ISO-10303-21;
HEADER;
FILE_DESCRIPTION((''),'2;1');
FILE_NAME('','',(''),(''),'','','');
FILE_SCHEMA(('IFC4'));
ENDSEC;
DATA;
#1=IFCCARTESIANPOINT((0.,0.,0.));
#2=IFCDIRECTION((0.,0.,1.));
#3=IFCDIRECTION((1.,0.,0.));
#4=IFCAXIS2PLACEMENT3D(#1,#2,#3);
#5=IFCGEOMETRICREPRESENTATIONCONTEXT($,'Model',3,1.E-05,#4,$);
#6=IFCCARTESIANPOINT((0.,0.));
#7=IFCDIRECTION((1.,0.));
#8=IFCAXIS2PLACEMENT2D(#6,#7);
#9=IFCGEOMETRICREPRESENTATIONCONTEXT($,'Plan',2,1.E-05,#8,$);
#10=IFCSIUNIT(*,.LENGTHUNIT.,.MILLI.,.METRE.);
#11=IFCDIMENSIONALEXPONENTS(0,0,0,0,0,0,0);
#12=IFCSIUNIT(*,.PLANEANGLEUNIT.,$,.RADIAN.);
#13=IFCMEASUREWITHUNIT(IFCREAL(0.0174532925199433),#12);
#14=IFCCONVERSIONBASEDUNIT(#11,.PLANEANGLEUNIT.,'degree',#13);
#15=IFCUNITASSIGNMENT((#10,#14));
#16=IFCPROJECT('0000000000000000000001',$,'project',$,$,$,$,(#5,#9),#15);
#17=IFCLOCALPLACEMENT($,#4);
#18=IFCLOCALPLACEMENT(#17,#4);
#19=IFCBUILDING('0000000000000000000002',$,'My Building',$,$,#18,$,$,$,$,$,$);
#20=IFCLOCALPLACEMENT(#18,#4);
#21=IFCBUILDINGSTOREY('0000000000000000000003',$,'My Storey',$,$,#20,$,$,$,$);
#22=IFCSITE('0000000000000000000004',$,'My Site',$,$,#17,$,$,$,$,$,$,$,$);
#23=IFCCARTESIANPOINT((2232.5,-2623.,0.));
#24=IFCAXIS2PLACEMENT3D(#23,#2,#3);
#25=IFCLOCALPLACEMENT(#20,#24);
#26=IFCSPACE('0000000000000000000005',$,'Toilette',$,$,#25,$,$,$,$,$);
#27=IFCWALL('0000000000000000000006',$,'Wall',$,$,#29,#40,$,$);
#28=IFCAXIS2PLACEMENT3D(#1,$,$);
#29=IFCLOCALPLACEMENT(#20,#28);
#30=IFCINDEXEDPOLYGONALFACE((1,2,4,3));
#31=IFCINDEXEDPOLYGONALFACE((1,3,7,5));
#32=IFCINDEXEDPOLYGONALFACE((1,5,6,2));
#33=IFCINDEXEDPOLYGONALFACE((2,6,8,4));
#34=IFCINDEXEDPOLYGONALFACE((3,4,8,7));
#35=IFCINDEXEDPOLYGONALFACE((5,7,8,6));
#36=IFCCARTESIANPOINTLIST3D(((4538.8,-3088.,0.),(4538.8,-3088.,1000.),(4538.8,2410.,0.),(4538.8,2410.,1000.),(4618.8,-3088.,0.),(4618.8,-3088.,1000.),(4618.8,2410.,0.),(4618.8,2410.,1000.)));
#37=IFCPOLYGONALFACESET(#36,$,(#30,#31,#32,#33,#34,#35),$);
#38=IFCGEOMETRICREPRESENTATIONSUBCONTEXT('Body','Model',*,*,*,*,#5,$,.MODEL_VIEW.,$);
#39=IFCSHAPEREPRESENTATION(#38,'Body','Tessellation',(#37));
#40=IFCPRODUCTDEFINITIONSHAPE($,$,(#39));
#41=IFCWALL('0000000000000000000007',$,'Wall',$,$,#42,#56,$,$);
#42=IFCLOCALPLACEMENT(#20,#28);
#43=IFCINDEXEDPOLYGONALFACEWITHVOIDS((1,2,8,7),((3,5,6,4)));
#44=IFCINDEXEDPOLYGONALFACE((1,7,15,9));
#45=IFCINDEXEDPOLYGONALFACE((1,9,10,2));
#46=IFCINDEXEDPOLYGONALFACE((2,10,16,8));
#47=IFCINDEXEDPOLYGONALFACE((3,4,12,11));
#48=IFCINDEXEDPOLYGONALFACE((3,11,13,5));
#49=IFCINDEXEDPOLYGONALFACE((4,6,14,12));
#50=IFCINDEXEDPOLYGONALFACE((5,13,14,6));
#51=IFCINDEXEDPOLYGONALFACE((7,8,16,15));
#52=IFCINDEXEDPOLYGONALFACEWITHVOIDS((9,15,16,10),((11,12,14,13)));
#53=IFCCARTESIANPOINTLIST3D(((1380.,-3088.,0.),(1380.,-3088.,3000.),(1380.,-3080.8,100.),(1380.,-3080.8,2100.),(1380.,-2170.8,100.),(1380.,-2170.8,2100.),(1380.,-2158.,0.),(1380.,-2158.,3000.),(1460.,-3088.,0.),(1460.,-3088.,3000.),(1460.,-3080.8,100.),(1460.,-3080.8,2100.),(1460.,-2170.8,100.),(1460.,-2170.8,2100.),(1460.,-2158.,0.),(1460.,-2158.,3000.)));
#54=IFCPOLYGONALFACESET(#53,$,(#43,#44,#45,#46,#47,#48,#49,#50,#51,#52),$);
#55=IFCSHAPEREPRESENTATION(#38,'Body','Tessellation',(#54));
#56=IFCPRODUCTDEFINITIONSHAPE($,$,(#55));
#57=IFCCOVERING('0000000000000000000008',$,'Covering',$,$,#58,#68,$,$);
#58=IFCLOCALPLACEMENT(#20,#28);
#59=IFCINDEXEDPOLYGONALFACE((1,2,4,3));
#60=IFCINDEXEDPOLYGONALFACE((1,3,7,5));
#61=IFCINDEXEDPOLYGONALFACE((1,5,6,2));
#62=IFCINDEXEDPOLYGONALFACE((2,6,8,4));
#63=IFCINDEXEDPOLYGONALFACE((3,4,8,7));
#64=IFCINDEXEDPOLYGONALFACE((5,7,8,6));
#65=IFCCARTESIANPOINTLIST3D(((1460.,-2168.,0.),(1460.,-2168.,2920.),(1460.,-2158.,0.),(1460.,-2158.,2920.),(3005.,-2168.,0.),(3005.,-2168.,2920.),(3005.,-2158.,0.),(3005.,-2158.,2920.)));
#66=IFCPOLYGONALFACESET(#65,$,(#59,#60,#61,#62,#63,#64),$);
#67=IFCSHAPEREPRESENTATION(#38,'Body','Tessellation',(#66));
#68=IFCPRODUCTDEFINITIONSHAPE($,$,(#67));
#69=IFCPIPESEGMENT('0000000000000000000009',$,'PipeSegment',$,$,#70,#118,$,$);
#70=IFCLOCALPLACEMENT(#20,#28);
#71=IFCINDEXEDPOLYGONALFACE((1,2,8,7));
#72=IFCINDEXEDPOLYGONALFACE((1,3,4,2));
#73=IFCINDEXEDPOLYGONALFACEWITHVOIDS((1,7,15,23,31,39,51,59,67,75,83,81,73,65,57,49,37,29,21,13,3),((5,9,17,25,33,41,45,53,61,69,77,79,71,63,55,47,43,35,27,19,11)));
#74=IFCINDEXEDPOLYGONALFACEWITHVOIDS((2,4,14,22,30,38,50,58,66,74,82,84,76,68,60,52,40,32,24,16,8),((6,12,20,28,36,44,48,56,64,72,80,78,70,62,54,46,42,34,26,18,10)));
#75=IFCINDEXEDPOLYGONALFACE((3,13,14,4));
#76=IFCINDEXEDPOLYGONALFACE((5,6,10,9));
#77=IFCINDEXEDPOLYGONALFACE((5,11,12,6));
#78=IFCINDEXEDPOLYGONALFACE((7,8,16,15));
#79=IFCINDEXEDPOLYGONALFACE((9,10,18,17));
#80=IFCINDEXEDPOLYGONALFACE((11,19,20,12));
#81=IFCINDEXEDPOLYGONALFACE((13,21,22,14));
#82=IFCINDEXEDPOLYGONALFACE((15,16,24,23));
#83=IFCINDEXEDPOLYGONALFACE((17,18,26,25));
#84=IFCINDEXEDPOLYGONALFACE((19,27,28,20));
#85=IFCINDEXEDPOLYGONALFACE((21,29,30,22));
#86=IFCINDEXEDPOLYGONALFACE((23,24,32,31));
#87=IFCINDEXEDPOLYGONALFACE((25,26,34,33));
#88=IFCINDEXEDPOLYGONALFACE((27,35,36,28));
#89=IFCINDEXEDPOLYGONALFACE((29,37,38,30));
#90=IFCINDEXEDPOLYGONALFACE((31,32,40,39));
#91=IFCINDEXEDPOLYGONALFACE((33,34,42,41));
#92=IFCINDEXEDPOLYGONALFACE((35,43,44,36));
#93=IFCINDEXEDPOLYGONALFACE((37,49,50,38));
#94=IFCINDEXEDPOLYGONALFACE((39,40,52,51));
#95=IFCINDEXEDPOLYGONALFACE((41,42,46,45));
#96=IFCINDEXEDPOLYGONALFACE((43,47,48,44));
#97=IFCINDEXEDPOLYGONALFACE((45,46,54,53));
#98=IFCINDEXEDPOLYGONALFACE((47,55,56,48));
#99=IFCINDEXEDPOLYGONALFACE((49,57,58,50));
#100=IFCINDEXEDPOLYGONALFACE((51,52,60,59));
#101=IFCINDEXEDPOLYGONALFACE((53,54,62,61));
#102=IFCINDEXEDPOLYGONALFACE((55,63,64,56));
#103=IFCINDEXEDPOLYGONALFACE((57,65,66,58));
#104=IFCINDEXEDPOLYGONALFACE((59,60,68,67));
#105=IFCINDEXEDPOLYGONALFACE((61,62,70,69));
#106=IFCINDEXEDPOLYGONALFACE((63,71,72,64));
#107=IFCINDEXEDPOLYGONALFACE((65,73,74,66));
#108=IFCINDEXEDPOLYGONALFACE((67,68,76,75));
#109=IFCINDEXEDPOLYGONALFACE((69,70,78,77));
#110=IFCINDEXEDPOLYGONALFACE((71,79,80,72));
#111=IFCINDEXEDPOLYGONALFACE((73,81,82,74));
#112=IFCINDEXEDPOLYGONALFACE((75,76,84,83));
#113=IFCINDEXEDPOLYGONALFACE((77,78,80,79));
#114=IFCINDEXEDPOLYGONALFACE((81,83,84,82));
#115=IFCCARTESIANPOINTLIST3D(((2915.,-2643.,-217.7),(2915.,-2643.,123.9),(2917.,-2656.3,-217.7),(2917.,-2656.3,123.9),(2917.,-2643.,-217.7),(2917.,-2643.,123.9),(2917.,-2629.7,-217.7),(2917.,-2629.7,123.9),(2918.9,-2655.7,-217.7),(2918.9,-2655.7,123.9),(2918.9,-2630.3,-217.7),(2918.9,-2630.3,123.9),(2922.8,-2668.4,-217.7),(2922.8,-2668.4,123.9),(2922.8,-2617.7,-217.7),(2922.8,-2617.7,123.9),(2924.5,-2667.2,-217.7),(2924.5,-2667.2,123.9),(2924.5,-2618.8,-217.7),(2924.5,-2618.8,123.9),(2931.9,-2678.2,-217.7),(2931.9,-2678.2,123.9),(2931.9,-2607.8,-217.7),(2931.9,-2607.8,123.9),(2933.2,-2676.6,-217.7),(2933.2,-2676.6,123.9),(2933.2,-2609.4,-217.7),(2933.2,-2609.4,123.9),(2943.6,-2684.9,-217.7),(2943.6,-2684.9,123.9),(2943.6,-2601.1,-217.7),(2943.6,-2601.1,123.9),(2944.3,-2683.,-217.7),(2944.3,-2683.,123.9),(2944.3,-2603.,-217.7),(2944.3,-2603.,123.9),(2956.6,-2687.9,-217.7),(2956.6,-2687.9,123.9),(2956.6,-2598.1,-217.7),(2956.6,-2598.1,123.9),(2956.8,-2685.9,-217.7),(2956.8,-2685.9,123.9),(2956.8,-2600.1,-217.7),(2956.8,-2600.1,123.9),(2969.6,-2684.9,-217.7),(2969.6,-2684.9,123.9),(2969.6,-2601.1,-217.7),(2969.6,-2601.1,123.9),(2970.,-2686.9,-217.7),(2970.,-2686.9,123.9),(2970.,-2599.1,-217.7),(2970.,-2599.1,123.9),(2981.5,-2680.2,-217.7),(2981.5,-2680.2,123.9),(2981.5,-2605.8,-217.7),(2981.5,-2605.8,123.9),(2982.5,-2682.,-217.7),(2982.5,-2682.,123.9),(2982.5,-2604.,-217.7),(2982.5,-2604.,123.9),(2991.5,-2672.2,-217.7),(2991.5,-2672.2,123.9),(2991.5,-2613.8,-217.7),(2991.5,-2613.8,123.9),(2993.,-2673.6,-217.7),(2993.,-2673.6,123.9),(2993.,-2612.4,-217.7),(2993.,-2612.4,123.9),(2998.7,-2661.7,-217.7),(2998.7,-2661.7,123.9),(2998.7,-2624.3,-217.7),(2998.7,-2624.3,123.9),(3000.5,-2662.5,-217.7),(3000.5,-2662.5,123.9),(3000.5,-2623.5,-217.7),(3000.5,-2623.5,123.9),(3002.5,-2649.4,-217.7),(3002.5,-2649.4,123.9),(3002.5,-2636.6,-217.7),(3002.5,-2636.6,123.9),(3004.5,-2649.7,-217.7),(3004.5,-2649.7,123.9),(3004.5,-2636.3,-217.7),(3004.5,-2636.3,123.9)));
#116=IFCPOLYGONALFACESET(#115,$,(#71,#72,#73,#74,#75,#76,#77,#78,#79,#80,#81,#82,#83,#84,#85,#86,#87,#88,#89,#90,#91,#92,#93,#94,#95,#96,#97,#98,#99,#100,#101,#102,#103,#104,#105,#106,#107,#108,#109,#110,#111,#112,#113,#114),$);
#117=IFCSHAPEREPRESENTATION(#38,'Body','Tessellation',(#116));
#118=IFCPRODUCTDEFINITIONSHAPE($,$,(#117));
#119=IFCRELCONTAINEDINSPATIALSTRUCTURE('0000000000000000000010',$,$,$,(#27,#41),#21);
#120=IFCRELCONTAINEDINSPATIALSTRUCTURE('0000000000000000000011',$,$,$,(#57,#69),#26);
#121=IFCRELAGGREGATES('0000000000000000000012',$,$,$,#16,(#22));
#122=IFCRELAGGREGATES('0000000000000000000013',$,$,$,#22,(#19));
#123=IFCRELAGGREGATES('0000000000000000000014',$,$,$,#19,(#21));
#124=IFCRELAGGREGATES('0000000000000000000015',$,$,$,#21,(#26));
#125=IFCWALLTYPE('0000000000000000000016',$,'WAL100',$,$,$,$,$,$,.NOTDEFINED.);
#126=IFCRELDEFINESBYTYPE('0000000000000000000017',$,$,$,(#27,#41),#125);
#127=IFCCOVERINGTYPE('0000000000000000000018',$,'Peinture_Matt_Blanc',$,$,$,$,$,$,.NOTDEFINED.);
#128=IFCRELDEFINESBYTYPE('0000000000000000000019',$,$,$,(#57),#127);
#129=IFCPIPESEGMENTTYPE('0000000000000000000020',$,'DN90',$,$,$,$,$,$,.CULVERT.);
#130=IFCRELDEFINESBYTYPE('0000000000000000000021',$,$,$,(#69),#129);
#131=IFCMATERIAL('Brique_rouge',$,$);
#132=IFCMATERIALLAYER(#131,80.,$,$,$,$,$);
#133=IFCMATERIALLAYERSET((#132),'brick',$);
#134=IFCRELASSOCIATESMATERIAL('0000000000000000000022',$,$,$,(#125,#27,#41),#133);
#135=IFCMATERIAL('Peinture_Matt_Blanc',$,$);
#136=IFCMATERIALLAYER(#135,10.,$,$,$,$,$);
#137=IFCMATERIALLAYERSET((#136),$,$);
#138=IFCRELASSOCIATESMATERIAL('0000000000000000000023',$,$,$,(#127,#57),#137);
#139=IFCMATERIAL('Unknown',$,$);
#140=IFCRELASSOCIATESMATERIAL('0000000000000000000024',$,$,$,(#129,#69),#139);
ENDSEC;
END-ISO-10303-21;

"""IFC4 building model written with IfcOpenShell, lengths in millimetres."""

from ifc_helpers import new_model, entity, si_unit, converted_unit, frame, origin_with_axes, origin_2d_with_axis, place, context, subcontext, project, spatial, line, indexed_curve, hollow_circle, outline, extrude, clip, halfspace, source, transform, mapped, material, layer, layer_set, layer_usage, material_profile, profile_set, profile_usage, type_object, element, save


model = new_model("IFC4")

# Units and contexts
model_context = context("Model", 3, precision=1e-05, world=origin_with_axes())
plan_context = context("Plan", 2, precision=1e-05, world=origin_2d_with_axis())
body_context_1 = subcontext(model_context, "Body", "Model", "MODEL_VIEW")
ifc_project = project(units=[si_unit("LENGTHUNIT", "METRE", prefix="MILLI"), converted_unit("PLANEANGLEUNIT", "degree", entity("IfcReal", 0.0174532925199433), si_unit("PLANEANGLEUNIT", "RADIAN"), dimensions=[0, 0, 0, 0, 0, 0, 0])], contexts=[model_context, plan_context])

# Site, building, storey
site_placement = place(None, origin_with_axes())
site = spatial("IfcSite", under=ifc_project, at=site_placement, Name="My Site")
building_placement = place(site_placement, origin_with_axes())
building = spatial("IfcBuilding", under=site, at=building_placement, Name="My Building")
storey_placement = place(building_placement, origin_with_axes())
storey = spatial("IfcBuildingStorey", under=building, at=storey_placement, Name="My Storey")

# Shared definitions
ifc_material_1 = material(Name="Unknown")

# Wall
ifc_material_2 = material(Name="Brique_rouge")
ifc_layer_1 = layer(ifc_material_2, 80.0)
ifc_layer_set_1 = layer_set([ifc_layer_1], Name="brick")
ifc_layer_usage_1 = layer_usage(ifc_layer_set_1, "AXIS2", "POSITIVE", 0.0)
wall_type = type_object("IfcWallType", Name="WAL100", PredefinedType="NOTDEFINED", material=ifc_layer_set_1)
wall_1_placement = place(storey_placement, frame((4618.8, -3088.0, 0.0), z_axis=(0.0, 0.0, 1.0), x_axis=(0.000002, 1.0, 0.0)))
element("IfcWall", 1, at=wall_1_placement, inside=storey, type_object=wall_type, material=ifc_layer_usage_1, Name="Wall", context=body_context_1, shape_type="SweptSolid", body=[
    extrude(outline(indexed_curve([(0.0, 0.0), (0.0, 80.0), (5498.0, 80.0), (5498.0, 0.0), (0.0, 0.0)], self_intersect=False)), origin_with_axes(), (0.0, 0.0, 1.0), 1000.0),
])

# Wall, opening
ifc_layer_usage_2 = layer_usage(ifc_layer_set_1, "AXIS2", "POSITIVE", 0.0)
wall_2_placement = place(storey_placement, frame((1380.0, -2158.0, 0.0), z_axis=(0.0, 0.0, 1.0), x_axis=(-0.000001, -1.0, 0.0)))
wall_2 = element("IfcWall", 2, at=wall_2_placement, inside=storey, type_object=wall_type, material=ifc_layer_usage_2, Name="Wall", context=body_context_1, shape_type="SweptSolid", body=[
    extrude(outline(indexed_curve([(0.0, 0.0), (0.0, 80.0), (930.0, 80.0), (930.0, 0.0), (0.0, 0.0)], self_intersect=False)), origin_with_axes(), (0.0, 0.0, 1.0), 3000.0),
])
shared_shape_1 = source(origin_with_axes(), body_context_1, "Body", "SweptSolid", [
    extrude(outline(indexed_curve([(0.0, 0.0), (910.0, 0.0), (910.0, 2000.0), (0.0, 2000.0)], segments=[line(3, 2), line(2, 1), line(1, 4), line(4, 3)], self_intersect=False)), frame((0.0, -100.0, 0.0), z_axis=(0.0, -1.0, 0.0), x_axis=(1.0, 0.0, 0.0)), (0.0, 0.0, -1.0), 280.0),
])
opening_1_placement = place(wall_2_placement, frame((12.8, -13.4, 100.0), z_axis=(0.0, 0.0, 1.0), x_axis=(1.0, 0.0, 0.0)))
element("IfcOpeningElement", 3, at=opening_1_placement, cuts=wall_2, PredefinedType="OPENING", context=body_context_1, shape_type="MappedRepresentation", body=[
    mapped(shared_shape_1, transform((0.0, 0.0, 0.0), x_axis=(1.0, 0.0, 0.0), y_axis=(0.0, 1.0, 0.0), z_axis=(0.0, 0.0, 1.0), scale=1.0)),
])

# Shared definitions
space_1_placement = place(storey_placement, frame((2232.5, -2623.0, 0.0), z_axis=(0.0, 0.0, 1.0), x_axis=(1.0, 0.0, 0.0)))
space_1 = spatial("IfcSpace", under=storey, at=space_1_placement, Name="Toilette")

# Shared definitions
ifc_material_3 = material(Name="Peinture_Matt_Blanc")
ifc_layer_2 = layer(ifc_material_3, 10.0)
ifc_layer_set_2 = layer_set([ifc_layer_2])
covering_type_1 = type_object("IfcCoveringType", Name="Peinture_Matt_Blanc", PredefinedType="NOTDEFINED", material=ifc_layer_set_2)

# Covering
ifc_layer_usage_3 = layer_usage(ifc_layer_set_2, "AXIS2", "POSITIVE", 0.0)
covering_1_placement = place(space_1_placement, frame((772.5, 465.0, 0.0), z_axis=(0.0, 0.0, 1.0), x_axis=(-1.0, 0.000002, 0.0)))
element("IfcCovering", 4, at=covering_1_placement, inside=space_1, type_object=covering_type_1, material=ifc_layer_usage_3, Name="Covering", context=body_context_1, shape_type="Clipping", body=[
    clip(clip(extrude(outline(indexed_curve([(0.0, 0.0), (0.0, 10.0), (1545.0, 10.0), (1545.0, 0.0), (0.0, 0.0)], self_intersect=False)), origin_with_axes(), (0.0, 0.0, 1.0), 2920.0), halfspace(frame((0.0, 0.0, 2920.0), z_axis=(0.0, 0.0, 1.0), x_axis=(-1.0, 0.0, 0.0)), False)), halfspace(frame((0.0, 0.0, 2920.0), z_axis=(0.0, 0.0, 1.0), x_axis=(-1.0, 0.0, 0.0)), False)),
])

# Pipe segment
ifc_material_profile = material_profile(ifc_material_1, hollow_circle(Radius=45.0, WallThickness=2.0))
ifc_profile_set = profile_set([ifc_material_profile])
pipe_segment_type = type_object("IfcPipeSegmentType", Name="DN90", PredefinedType="CULVERT", material=ifc_profile_set)
ifc_profile_usage_1 = profile_usage(ifc_profile_set, cardinal=5)
pipe_segment_1_placement = place(space_1_placement, frame((727.5, -20.0, 123.9), z_axis=(0.0, 0.0, -1.0), x_axis=(-1.0, 0.0, 0.0)))
element("IfcPipeSegment", 5, at=pipe_segment_1_placement, inside=space_1, type_object=pipe_segment_type, material=ifc_profile_usage_1, Name="PipeSegment", context=body_context_1, shape_type="SweptSolid", body=[
    extrude(hollow_circle(Radius=45.0, WallThickness=2.0), origin_with_axes(), (0.0, 0.0, 1.0), 341.5),
])

save(model, "model.ifc")
